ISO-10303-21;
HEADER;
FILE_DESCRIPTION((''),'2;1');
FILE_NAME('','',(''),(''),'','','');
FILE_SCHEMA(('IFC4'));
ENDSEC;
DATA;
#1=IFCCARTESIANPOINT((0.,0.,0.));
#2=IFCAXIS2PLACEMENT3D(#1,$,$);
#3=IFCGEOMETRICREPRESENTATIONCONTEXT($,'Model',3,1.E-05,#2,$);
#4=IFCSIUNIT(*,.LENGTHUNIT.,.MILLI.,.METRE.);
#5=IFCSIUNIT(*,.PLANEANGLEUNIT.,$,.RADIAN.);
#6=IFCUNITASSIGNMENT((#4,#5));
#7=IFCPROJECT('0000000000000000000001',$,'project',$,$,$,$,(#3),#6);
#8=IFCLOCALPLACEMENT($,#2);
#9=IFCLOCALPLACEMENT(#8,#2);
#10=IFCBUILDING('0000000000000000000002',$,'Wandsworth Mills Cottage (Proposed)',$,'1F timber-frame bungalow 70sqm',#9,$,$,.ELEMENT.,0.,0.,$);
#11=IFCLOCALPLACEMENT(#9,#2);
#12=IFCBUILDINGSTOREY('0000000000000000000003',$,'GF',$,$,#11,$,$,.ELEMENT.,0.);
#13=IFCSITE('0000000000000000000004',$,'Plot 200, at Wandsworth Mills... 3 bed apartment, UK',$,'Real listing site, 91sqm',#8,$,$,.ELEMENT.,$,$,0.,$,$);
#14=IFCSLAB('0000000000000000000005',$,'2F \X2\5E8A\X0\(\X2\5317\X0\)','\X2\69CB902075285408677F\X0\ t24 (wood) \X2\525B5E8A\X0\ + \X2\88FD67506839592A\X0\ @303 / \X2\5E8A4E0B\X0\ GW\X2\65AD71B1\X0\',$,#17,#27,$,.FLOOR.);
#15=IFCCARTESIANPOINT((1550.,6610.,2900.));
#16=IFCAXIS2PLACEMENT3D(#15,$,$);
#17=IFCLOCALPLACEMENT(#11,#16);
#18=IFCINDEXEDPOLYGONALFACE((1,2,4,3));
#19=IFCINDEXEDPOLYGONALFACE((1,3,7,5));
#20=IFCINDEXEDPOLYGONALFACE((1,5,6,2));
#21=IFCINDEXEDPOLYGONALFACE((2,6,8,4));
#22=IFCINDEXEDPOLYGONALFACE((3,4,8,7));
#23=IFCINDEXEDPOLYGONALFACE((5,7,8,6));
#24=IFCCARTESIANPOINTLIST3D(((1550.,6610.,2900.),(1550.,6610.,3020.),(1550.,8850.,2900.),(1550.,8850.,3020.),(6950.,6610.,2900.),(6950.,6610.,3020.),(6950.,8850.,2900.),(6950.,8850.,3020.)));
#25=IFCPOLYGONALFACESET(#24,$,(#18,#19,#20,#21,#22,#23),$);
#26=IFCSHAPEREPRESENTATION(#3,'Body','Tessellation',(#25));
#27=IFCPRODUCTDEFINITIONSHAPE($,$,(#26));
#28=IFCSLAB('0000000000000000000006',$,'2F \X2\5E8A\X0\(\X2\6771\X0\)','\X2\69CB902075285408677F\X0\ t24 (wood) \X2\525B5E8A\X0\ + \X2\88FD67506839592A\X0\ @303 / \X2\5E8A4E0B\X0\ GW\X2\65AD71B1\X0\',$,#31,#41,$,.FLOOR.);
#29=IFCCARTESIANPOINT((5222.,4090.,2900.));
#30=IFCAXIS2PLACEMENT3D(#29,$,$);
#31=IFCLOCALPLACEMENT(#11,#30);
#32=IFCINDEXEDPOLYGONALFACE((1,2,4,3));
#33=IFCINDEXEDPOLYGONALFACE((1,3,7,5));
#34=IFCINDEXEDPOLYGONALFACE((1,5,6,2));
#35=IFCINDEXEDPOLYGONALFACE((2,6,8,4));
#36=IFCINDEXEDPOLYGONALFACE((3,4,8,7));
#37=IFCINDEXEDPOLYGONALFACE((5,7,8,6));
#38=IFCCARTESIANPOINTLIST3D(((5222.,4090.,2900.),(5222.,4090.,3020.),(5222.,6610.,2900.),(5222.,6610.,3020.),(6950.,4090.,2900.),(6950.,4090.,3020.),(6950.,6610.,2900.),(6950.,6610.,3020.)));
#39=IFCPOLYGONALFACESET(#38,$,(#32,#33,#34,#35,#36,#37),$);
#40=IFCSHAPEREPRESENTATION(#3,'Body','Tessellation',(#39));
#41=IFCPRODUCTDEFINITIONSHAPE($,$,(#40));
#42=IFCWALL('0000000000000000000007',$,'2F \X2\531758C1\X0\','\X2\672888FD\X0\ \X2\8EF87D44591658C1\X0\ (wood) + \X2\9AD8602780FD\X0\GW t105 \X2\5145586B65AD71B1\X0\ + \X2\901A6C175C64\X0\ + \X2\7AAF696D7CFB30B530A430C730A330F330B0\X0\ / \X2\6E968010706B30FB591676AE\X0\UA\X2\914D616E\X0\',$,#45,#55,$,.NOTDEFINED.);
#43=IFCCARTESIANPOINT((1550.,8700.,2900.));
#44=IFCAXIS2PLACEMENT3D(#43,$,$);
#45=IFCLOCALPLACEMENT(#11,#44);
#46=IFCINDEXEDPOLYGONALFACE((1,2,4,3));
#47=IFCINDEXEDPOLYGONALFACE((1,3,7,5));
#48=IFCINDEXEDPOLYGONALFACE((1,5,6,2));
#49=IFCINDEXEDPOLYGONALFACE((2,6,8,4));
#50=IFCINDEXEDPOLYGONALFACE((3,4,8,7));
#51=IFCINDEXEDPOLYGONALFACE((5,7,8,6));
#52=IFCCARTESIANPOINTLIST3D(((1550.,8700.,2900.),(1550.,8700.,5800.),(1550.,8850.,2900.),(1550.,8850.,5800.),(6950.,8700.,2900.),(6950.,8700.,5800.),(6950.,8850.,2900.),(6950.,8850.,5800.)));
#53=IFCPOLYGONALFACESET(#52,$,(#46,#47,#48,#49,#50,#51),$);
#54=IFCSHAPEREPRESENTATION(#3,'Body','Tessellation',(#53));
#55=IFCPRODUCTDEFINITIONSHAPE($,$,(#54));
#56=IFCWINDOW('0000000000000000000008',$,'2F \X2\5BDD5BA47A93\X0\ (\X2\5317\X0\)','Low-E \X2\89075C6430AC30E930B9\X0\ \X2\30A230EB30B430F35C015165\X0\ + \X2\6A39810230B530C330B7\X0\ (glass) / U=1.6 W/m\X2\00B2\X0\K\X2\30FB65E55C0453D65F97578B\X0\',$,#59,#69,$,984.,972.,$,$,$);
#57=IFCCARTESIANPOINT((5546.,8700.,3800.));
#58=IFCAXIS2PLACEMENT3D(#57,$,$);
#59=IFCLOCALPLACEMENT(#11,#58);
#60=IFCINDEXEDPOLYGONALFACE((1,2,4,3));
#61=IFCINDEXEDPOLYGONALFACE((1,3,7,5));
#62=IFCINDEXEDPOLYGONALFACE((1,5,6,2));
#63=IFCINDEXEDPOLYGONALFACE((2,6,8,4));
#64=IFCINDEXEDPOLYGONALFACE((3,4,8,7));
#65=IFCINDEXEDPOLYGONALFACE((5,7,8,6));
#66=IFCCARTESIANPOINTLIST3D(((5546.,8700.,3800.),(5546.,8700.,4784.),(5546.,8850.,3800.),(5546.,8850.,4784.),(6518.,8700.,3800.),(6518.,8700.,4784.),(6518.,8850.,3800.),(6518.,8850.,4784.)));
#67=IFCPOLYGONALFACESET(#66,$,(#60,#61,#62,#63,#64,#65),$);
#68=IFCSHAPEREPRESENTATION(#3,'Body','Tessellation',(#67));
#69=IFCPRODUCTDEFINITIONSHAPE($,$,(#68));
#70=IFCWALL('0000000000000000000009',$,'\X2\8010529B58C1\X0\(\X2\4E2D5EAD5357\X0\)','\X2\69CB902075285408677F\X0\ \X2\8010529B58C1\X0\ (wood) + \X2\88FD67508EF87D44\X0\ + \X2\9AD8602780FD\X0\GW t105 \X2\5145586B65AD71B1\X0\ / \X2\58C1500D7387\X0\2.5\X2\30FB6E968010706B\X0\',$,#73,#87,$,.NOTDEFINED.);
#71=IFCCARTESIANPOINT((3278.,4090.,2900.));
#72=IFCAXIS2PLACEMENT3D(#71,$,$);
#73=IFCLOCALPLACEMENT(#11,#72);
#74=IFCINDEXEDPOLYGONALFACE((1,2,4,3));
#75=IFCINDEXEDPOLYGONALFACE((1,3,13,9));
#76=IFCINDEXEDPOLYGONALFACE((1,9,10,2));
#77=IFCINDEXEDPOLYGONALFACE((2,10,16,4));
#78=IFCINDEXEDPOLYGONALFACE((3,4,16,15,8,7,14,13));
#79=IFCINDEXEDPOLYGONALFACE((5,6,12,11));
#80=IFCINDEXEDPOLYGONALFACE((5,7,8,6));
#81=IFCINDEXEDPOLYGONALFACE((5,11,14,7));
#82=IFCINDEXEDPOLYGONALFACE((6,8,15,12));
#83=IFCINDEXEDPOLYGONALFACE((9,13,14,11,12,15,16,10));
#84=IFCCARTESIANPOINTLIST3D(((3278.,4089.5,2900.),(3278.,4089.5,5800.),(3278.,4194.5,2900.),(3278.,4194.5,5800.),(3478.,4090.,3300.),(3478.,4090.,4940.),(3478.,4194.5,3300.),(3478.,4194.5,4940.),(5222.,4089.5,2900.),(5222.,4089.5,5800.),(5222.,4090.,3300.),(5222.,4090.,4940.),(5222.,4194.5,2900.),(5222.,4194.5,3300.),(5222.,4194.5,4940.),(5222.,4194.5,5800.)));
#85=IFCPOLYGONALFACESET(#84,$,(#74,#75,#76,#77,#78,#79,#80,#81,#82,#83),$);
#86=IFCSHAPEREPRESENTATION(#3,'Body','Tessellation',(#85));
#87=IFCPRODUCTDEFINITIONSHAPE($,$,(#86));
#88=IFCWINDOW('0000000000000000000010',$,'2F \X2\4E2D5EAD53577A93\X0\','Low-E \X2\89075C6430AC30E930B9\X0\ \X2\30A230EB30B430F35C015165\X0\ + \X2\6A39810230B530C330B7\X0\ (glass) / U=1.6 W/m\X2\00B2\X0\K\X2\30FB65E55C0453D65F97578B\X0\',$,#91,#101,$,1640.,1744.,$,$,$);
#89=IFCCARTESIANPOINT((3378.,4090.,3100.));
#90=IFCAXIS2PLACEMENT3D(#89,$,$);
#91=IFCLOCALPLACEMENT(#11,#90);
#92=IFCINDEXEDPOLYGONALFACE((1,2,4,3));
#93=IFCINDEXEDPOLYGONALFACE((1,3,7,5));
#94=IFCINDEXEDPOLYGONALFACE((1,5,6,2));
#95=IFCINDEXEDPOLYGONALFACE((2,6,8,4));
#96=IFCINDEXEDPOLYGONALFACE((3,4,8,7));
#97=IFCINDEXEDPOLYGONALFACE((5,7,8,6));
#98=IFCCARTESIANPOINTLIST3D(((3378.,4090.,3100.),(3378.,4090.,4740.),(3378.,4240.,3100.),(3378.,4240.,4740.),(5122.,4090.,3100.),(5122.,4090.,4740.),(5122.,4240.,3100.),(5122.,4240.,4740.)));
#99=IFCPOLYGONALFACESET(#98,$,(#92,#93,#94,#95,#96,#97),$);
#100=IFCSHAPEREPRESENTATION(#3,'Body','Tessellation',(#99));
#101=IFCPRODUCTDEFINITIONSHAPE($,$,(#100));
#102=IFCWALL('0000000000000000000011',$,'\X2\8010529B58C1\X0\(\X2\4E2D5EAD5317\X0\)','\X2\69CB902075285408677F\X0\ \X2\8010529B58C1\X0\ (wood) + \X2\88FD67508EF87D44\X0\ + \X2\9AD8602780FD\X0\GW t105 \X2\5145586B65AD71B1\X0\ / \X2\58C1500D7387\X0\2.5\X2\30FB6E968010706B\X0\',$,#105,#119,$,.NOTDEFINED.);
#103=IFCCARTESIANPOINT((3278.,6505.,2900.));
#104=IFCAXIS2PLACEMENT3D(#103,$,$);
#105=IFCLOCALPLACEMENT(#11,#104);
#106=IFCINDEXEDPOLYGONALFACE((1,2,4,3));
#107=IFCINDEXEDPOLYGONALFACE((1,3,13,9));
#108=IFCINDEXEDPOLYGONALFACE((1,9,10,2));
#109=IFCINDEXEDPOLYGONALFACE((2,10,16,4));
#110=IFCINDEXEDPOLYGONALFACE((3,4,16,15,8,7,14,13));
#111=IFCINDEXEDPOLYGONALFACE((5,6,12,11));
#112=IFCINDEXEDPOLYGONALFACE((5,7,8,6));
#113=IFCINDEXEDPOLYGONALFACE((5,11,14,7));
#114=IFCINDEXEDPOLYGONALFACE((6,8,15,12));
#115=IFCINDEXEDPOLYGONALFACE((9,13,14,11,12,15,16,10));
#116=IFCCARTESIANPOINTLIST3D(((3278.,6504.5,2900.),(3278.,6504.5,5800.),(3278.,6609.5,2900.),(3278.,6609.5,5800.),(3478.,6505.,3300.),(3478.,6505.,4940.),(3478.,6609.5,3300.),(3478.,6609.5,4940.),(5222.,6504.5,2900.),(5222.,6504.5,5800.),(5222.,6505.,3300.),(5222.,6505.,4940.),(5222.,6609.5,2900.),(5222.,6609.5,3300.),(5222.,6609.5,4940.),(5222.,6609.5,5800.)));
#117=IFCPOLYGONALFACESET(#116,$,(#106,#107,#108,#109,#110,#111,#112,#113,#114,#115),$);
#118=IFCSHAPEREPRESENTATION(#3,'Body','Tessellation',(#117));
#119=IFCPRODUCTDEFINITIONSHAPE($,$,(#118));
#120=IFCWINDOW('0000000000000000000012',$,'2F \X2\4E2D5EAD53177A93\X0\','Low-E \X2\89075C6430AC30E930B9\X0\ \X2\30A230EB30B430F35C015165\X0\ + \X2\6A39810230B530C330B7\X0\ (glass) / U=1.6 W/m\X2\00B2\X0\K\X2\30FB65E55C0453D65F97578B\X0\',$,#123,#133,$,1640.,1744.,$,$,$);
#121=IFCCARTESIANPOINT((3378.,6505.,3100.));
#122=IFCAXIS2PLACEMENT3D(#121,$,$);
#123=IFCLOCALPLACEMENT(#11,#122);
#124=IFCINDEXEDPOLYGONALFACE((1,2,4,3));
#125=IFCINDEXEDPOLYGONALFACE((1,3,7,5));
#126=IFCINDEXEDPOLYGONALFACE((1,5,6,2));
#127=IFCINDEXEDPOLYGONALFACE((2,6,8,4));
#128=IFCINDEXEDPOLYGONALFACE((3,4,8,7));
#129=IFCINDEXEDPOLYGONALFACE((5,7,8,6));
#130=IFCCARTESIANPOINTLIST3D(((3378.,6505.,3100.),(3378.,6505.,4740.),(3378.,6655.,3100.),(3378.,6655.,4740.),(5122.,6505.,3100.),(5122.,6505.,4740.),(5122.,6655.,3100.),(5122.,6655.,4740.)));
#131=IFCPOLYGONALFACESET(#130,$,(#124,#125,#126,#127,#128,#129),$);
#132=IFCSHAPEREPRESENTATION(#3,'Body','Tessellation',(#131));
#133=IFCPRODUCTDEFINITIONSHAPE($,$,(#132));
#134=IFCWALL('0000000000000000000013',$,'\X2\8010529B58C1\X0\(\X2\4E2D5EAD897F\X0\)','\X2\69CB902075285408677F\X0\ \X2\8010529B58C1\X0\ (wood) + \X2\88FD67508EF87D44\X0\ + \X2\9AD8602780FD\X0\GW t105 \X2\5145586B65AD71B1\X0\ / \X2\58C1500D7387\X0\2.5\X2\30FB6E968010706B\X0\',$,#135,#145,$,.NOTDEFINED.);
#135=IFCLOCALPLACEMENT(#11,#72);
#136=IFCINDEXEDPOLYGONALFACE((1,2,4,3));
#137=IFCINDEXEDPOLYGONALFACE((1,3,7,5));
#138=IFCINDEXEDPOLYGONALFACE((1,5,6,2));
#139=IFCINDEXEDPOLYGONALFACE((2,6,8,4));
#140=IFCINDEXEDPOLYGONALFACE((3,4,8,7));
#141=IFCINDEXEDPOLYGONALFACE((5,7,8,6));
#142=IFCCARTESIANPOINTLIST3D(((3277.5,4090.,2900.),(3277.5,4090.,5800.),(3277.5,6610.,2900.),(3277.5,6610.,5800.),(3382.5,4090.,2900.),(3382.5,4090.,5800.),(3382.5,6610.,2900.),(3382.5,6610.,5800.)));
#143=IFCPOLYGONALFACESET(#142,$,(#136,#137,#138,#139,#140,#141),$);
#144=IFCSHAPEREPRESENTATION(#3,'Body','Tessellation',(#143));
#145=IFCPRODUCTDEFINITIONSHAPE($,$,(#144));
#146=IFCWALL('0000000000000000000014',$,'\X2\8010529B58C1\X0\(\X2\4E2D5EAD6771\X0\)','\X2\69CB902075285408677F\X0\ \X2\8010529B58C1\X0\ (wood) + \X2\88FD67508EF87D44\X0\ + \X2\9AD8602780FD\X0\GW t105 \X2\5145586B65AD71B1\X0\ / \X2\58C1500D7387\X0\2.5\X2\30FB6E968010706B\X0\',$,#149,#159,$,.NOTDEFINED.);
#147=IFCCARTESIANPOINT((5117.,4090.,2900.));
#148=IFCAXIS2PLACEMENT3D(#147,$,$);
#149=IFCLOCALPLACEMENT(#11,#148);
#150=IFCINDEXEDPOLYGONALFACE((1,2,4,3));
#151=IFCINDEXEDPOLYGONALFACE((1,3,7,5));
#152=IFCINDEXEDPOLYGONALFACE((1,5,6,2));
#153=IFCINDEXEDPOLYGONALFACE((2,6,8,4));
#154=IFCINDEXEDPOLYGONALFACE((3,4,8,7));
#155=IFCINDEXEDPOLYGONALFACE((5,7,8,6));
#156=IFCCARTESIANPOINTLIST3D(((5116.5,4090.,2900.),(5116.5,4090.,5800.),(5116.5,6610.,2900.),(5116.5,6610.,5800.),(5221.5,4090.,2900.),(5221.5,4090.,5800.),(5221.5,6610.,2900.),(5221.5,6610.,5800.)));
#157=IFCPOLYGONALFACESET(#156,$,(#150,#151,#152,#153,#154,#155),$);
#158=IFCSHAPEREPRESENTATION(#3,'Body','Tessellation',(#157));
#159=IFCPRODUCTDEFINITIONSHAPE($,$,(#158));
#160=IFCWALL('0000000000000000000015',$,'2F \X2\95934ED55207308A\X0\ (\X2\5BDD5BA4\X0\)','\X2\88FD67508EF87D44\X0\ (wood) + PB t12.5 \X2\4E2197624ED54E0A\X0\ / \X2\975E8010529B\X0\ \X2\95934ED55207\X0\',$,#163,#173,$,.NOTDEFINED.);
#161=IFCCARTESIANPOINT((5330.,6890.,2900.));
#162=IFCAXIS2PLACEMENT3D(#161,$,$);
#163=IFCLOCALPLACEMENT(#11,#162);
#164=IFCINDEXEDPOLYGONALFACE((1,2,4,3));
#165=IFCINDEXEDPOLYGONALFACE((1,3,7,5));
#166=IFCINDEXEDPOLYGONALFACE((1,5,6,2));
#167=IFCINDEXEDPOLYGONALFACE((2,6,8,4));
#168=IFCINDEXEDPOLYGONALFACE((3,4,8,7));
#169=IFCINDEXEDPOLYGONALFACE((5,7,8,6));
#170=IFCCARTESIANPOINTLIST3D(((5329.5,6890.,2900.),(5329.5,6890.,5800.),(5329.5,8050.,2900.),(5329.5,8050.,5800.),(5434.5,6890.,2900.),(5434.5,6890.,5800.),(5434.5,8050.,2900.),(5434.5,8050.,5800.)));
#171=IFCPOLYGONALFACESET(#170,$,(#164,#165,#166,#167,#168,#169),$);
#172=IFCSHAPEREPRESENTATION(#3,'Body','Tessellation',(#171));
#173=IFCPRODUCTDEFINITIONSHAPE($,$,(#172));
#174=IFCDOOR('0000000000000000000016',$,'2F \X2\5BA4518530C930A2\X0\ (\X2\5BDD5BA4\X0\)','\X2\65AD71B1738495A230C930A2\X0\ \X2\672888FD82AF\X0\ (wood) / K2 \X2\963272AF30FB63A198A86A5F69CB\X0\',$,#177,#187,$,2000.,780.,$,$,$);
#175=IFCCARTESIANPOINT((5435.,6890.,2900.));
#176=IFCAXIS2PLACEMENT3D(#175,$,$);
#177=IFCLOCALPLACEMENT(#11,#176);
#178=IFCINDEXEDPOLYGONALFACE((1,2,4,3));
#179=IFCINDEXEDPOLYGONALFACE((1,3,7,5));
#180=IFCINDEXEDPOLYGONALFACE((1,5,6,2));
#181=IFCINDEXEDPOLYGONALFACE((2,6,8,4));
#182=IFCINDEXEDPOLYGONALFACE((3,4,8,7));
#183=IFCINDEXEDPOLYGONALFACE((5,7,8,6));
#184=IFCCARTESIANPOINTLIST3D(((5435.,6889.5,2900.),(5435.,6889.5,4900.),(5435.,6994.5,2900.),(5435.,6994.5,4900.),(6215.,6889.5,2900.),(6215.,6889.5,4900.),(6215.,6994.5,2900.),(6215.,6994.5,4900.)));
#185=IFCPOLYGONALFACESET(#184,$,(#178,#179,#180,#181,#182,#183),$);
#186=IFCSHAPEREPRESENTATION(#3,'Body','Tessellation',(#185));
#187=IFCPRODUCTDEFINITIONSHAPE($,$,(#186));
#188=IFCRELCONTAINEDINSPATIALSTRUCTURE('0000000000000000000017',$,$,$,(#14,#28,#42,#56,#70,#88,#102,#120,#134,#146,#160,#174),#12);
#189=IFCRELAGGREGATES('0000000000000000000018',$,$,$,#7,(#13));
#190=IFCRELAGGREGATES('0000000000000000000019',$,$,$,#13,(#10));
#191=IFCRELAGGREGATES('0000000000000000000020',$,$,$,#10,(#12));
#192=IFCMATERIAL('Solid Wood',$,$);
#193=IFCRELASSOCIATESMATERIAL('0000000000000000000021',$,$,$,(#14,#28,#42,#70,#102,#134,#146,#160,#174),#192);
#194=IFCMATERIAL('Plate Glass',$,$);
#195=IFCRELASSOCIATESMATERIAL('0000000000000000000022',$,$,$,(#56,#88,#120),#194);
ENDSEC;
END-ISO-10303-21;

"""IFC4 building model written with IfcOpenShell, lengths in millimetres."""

from ifc_helpers import new_model, si_unit, frame, frame_2d, origin, place, context, project, spatial, rectangle, extrude, material, element, fill, save


model = new_model("IFC4")

# Units and contexts
model_context = context("Model", 3, precision=1e-05, world=origin())
ifc_project = project(units=[si_unit("LENGTHUNIT", "METRE", prefix="MILLI"), si_unit("PLANEANGLEUNIT", "RADIAN")], contexts=[model_context])

# Site, building, storey
site_placement = place(None, origin())
site = spatial("IfcSite", under=ifc_project, at=site_placement, Name="Plot 200, at Wandsworth Mills... 3 bed apartment, UK", ObjectType="Real listing site, 91sqm", CompositionType="ELEMENT", RefElevation=0.0)
building_placement = place(site_placement, origin())
building = spatial("IfcBuilding", under=site, at=building_placement, Name="Wandsworth Mills Cottage (Proposed)", ObjectType="1F timber-frame bungalow 70sqm", CompositionType="ELEMENT", ElevationOfRefHeight=0.0, ElevationOfTerrain=0.0)
storey_placement = place(building_placement, origin())
storey = spatial("IfcBuildingStorey", under=building, at=storey_placement, Name="GF", CompositionType="ELEMENT", Elevation=0.0)

# Slabs
ifc_material_1 = material(Name="Solid Wood")
slab_1_placement = place(storey_placement, frame((1550.0, 6610.0, 2900.0)))
element("IfcSlab", 1, at=slab_1_placement, inside=storey, material=ifc_material_1, Name="2F 床(北)", Description="構造用合板 t24 (wood) 剛床 + 製材根太 @303 / 床下 GW断熱", PredefinedType="FLOOR", context=model_context, shape_type="SweptSolid", body=[
    extrude(rectangle(XDim=5400.0, YDim=2240.0, at=frame_2d((2700.0, 1120.0))), frame((1550.0, 6610.0, 2900.0)), (0.0, 0.0, 1.0), 120.0),
])
slab_2_placement = place(storey_placement, frame((5222.0, 4090.0, 2900.0)))
element("IfcSlab", 2, at=slab_2_placement, inside=storey, material=ifc_material_1, Name="2F 床(東)", Description="構造用合板 t24 (wood) 剛床 + 製材根太 @303 / 床下 GW断熱", PredefinedType="FLOOR", context=model_context, shape_type="SweptSolid", body=[
    extrude(rectangle(XDim=1728.0, YDim=2520.0, at=frame_2d((864.0, 1260.0))), frame((5222.0, 4090.0, 2900.0)), (0.0, 0.0, 1.0), 120.0),
])

# Walls, openings, windows
wall_1_placement = place(storey_placement, frame((1550.0, 8700.0, 2900.0)))
wall_1 = element("IfcWall", 3, at=wall_1_placement, inside=storey, material=ifc_material_1, Name="2F 北壁", Description="木製 軸組外壁 (wood) + 高性能GW t105 充填断熱 + 通気層 + 窯業系サイディング / 準耐火・外皮UA配慮", PredefinedType="NOTDEFINED", context=model_context, shape_type="SweptSolid", body=[
    extrude(rectangle(XDim=5400.0, YDim=150.0, at=frame_2d((2700.0, 75.0))), frame((1550.0, 8700.0, 2900.0)), (0.0, 0.0, 1.0), 2900.0),
])
opening_1_placement = place(storey_placement, frame((5546.0, 8700.0, 3800.0)))
opening_1 = element("IfcOpeningElement", 4, at=opening_1_placement, cuts=wall_1, PredefinedType="NOTDEFINED", context=model_context, shape_type="SweptSolid", body=[
    extrude(rectangle(XDim=972.0, YDim=150.0, at=frame_2d((486.0, 75.0))), frame((5546.0, 8700.0, 3800.0)), (0.0, 0.0, 1.0), 984.0),
])
ifc_material_2 = material(Name="Plate Glass")
window_1_placement = place(storey_placement, frame((5546.0, 8700.0, 3800.0)))
window_1 = element("IfcWindow", 5, at=window_1_placement, inside=storey, material=ifc_material_2, Name="2F 寝室窓 (北)", Description="Low-E 複層ガラス アルゴン封入 + 樹脂サッシ (glass) / U=1.6 W/m²K・日射取得型", OverallHeight=984.0, OverallWidth=972.0, context=model_context, shape_type="SweptSolid", body=[
    extrude(rectangle(XDim=972.0, YDim=150.0, at=frame_2d((486.0, 75.0))), frame((5546.0, 8700.0, 3800.0)), (0.0, 0.0, 1.0), 984.0),
])
fill(opening_1, window_1)
wall_2_placement = place(storey_placement, frame((3278.0, 4090.0, 2900.0)))
wall_2 = element("IfcWall", 6, at=wall_2_placement, inside=storey, material=ifc_material_1, Name="耐力壁(中庭南)", Description="構造用合板 耐力壁 (wood) + 製材軸組 + 高性能GW t105 充填断熱 / 壁倍率2.5・準耐火", PredefinedType="NOTDEFINED", context=model_context, shape_type="SweptSolid", body=[
    extrude(rectangle(XDim=1944.0, YDim=105.0, at=frame_2d((972.0, 52.0))), frame((3278.0, 4090.0, 2900.0)), (0.0, 0.0, 1.0), 2900.0),
])
opening_2_placement = place(storey_placement, frame((3378.0, 4090.0, 3100.0)))
opening_2 = element("IfcOpeningElement", 7, at=opening_2_placement, cuts=wall_2, PredefinedType="NOTDEFINED", context=model_context, shape_type="SweptSolid", body=[
    extrude(rectangle(XDim=1744.0, YDim=150.0, at=frame_2d((872.0, 75.0))), frame((3378.0, 4090.0, 3100.0)), (0.0, 0.0, 1.0), 1640.0),
])
window_2_placement = place(storey_placement, frame((3378.0, 4090.0, 3100.0)))
window_2 = element("IfcWindow", 8, at=window_2_placement, inside=storey, material=ifc_material_2, Name="2F 中庭南窓", Description="Low-E 複層ガラス アルゴン封入 + 樹脂サッシ (glass) / U=1.6 W/m²K・日射取得型", OverallHeight=1640.0, OverallWidth=1744.0, context=model_context, shape_type="SweptSolid", body=[
    extrude(rectangle(XDim=1744.0, YDim=150.0, at=frame_2d((872.0, 75.0))), frame((3378.0, 4090.0, 3100.0)), (0.0, 0.0, 1.0), 1640.0),
])
fill(opening_2, window_2)
wall_3_placement = place(storey_placement, frame((3278.0, 6505.0, 2900.0)))
wall_3 = element("IfcWall", 9, at=wall_3_placement, inside=storey, material=ifc_material_1, Name="耐力壁(中庭北)", Description="構造用合板 耐力壁 (wood) + 製材軸組 + 高性能GW t105 充填断熱 / 壁倍率2.5・準耐火", PredefinedType="NOTDEFINED", context=model_context, shape_type="SweptSolid", body=[
    extrude(rectangle(XDim=1944.0, YDim=105.0, at=frame_2d((972.0, 52.0))), frame((3278.0, 6505.0, 2900.0)), (0.0, 0.0, 1.0), 2900.0),
])
opening_3_placement = place(storey_placement, frame((3378.0, 6505.0, 3100.0)))
opening_3 = element("IfcOpeningElement", 10, at=opening_3_placement, cuts=wall_3, PredefinedType="NOTDEFINED", context=model_context, shape_type="SweptSolid", body=[
    extrude(rectangle(XDim=1744.0, YDim=150.0, at=frame_2d((872.0, 75.0))), frame((3378.0, 6505.0, 3100.0)), (0.0, 0.0, 1.0), 1640.0),
])
window_3_placement = place(storey_placement, frame((3378.0, 6505.0, 3100.0)))
window_3 = element("IfcWindow", 11, at=window_3_placement, inside=storey, material=ifc_material_2, Name="2F 中庭北窓", Description="Low-E 複層ガラス アルゴン封入 + 樹脂サッシ (glass) / U=1.6 W/m²K・日射取得型", OverallHeight=1640.0, OverallWidth=1744.0, context=model_context, shape_type="SweptSolid", body=[
    extrude(rectangle(XDim=1744.0, YDim=150.0, at=frame_2d((872.0, 75.0))), frame((3378.0, 6505.0, 3100.0)), (0.0, 0.0, 1.0), 1640.0),
])
fill(opening_3, window_3)

# Walls
wall_4_placement = place(storey_placement, frame((3278.0, 4090.0, 2900.0)))
element("IfcWall", 12, at=wall_4_placement, inside=storey, material=ifc_material_1, Name="耐力壁(中庭西)", Description="構造用合板 耐力壁 (wood) + 製材軸組 + 高性能GW t105 充填断熱 / 壁倍率2.5・準耐火", PredefinedType="NOTDEFINED", context=model_context, shape_type="SweptSolid", body=[
    extrude(rectangle(XDim=105.0, YDim=2520.0, at=frame_2d((52.0, 1260.0))), frame((3278.0, 4090.0, 2900.0)), (0.0, 0.0, 1.0), 2900.0),
])
wall_5_placement = place(storey_placement, frame((5117.0, 4090.0, 2900.0)))
element("IfcWall", 13, at=wall_5_placement, inside=storey, material=ifc_material_1, Name="耐力壁(中庭東)", Description="構造用合板 耐力壁 (wood) + 製材軸組 + 高性能GW t105 充填断熱 / 壁倍率2.5・準耐火", PredefinedType="NOTDEFINED", context=model_context, shape_type="SweptSolid", body=[
    extrude(rectangle(XDim=105.0, YDim=2520.0, at=frame_2d((52.0, 1260.0))), frame((5117.0, 4090.0, 2900.0)), (0.0, 0.0, 1.0), 2900.0),
])
wall_6_placement = place(storey_placement, frame((5330.0, 6890.0, 2900.0)))
element("IfcWall", 14, at=wall_6_placement, inside=storey, material=ifc_material_1, Name="2F 間仕切り (寝室)", Description="製材軸組 (wood) + PB t12.5 両面仕上 / 非耐力 間仕切", PredefinedType="NOTDEFINED", context=model_context, shape_type="SweptSolid", body=[
    extrude(rectangle(XDim=105.0, YDim=1160.0, at=frame_2d((52.0, 580.0))), frame((5330.0, 6890.0, 2900.0)), (0.0, 0.0, 1.0), 2900.0),
])

# Door
door_placement = place(storey_placement, frame((5435.0, 6890.0, 2900.0)))
element("IfcDoor", 15, at=door_placement, inside=storey, material=ifc_material_1, Name="2F 室内ドア (寝室)", Description="断熱玄関ドア 木製芯 (wood) / K2 防犯・採風機構", OverallHeight=2000.0, OverallWidth=780.0, context=model_context, shape_type="SweptSolid", body=[
    extrude(rectangle(XDim=780.0, YDim=105.0, at=frame_2d((390.0, 52.0))), frame((5435.0, 6890.0, 2900.0)), (0.0, 0.0, 1.0), 2000.0),
])

save(model, "model.ifc")
